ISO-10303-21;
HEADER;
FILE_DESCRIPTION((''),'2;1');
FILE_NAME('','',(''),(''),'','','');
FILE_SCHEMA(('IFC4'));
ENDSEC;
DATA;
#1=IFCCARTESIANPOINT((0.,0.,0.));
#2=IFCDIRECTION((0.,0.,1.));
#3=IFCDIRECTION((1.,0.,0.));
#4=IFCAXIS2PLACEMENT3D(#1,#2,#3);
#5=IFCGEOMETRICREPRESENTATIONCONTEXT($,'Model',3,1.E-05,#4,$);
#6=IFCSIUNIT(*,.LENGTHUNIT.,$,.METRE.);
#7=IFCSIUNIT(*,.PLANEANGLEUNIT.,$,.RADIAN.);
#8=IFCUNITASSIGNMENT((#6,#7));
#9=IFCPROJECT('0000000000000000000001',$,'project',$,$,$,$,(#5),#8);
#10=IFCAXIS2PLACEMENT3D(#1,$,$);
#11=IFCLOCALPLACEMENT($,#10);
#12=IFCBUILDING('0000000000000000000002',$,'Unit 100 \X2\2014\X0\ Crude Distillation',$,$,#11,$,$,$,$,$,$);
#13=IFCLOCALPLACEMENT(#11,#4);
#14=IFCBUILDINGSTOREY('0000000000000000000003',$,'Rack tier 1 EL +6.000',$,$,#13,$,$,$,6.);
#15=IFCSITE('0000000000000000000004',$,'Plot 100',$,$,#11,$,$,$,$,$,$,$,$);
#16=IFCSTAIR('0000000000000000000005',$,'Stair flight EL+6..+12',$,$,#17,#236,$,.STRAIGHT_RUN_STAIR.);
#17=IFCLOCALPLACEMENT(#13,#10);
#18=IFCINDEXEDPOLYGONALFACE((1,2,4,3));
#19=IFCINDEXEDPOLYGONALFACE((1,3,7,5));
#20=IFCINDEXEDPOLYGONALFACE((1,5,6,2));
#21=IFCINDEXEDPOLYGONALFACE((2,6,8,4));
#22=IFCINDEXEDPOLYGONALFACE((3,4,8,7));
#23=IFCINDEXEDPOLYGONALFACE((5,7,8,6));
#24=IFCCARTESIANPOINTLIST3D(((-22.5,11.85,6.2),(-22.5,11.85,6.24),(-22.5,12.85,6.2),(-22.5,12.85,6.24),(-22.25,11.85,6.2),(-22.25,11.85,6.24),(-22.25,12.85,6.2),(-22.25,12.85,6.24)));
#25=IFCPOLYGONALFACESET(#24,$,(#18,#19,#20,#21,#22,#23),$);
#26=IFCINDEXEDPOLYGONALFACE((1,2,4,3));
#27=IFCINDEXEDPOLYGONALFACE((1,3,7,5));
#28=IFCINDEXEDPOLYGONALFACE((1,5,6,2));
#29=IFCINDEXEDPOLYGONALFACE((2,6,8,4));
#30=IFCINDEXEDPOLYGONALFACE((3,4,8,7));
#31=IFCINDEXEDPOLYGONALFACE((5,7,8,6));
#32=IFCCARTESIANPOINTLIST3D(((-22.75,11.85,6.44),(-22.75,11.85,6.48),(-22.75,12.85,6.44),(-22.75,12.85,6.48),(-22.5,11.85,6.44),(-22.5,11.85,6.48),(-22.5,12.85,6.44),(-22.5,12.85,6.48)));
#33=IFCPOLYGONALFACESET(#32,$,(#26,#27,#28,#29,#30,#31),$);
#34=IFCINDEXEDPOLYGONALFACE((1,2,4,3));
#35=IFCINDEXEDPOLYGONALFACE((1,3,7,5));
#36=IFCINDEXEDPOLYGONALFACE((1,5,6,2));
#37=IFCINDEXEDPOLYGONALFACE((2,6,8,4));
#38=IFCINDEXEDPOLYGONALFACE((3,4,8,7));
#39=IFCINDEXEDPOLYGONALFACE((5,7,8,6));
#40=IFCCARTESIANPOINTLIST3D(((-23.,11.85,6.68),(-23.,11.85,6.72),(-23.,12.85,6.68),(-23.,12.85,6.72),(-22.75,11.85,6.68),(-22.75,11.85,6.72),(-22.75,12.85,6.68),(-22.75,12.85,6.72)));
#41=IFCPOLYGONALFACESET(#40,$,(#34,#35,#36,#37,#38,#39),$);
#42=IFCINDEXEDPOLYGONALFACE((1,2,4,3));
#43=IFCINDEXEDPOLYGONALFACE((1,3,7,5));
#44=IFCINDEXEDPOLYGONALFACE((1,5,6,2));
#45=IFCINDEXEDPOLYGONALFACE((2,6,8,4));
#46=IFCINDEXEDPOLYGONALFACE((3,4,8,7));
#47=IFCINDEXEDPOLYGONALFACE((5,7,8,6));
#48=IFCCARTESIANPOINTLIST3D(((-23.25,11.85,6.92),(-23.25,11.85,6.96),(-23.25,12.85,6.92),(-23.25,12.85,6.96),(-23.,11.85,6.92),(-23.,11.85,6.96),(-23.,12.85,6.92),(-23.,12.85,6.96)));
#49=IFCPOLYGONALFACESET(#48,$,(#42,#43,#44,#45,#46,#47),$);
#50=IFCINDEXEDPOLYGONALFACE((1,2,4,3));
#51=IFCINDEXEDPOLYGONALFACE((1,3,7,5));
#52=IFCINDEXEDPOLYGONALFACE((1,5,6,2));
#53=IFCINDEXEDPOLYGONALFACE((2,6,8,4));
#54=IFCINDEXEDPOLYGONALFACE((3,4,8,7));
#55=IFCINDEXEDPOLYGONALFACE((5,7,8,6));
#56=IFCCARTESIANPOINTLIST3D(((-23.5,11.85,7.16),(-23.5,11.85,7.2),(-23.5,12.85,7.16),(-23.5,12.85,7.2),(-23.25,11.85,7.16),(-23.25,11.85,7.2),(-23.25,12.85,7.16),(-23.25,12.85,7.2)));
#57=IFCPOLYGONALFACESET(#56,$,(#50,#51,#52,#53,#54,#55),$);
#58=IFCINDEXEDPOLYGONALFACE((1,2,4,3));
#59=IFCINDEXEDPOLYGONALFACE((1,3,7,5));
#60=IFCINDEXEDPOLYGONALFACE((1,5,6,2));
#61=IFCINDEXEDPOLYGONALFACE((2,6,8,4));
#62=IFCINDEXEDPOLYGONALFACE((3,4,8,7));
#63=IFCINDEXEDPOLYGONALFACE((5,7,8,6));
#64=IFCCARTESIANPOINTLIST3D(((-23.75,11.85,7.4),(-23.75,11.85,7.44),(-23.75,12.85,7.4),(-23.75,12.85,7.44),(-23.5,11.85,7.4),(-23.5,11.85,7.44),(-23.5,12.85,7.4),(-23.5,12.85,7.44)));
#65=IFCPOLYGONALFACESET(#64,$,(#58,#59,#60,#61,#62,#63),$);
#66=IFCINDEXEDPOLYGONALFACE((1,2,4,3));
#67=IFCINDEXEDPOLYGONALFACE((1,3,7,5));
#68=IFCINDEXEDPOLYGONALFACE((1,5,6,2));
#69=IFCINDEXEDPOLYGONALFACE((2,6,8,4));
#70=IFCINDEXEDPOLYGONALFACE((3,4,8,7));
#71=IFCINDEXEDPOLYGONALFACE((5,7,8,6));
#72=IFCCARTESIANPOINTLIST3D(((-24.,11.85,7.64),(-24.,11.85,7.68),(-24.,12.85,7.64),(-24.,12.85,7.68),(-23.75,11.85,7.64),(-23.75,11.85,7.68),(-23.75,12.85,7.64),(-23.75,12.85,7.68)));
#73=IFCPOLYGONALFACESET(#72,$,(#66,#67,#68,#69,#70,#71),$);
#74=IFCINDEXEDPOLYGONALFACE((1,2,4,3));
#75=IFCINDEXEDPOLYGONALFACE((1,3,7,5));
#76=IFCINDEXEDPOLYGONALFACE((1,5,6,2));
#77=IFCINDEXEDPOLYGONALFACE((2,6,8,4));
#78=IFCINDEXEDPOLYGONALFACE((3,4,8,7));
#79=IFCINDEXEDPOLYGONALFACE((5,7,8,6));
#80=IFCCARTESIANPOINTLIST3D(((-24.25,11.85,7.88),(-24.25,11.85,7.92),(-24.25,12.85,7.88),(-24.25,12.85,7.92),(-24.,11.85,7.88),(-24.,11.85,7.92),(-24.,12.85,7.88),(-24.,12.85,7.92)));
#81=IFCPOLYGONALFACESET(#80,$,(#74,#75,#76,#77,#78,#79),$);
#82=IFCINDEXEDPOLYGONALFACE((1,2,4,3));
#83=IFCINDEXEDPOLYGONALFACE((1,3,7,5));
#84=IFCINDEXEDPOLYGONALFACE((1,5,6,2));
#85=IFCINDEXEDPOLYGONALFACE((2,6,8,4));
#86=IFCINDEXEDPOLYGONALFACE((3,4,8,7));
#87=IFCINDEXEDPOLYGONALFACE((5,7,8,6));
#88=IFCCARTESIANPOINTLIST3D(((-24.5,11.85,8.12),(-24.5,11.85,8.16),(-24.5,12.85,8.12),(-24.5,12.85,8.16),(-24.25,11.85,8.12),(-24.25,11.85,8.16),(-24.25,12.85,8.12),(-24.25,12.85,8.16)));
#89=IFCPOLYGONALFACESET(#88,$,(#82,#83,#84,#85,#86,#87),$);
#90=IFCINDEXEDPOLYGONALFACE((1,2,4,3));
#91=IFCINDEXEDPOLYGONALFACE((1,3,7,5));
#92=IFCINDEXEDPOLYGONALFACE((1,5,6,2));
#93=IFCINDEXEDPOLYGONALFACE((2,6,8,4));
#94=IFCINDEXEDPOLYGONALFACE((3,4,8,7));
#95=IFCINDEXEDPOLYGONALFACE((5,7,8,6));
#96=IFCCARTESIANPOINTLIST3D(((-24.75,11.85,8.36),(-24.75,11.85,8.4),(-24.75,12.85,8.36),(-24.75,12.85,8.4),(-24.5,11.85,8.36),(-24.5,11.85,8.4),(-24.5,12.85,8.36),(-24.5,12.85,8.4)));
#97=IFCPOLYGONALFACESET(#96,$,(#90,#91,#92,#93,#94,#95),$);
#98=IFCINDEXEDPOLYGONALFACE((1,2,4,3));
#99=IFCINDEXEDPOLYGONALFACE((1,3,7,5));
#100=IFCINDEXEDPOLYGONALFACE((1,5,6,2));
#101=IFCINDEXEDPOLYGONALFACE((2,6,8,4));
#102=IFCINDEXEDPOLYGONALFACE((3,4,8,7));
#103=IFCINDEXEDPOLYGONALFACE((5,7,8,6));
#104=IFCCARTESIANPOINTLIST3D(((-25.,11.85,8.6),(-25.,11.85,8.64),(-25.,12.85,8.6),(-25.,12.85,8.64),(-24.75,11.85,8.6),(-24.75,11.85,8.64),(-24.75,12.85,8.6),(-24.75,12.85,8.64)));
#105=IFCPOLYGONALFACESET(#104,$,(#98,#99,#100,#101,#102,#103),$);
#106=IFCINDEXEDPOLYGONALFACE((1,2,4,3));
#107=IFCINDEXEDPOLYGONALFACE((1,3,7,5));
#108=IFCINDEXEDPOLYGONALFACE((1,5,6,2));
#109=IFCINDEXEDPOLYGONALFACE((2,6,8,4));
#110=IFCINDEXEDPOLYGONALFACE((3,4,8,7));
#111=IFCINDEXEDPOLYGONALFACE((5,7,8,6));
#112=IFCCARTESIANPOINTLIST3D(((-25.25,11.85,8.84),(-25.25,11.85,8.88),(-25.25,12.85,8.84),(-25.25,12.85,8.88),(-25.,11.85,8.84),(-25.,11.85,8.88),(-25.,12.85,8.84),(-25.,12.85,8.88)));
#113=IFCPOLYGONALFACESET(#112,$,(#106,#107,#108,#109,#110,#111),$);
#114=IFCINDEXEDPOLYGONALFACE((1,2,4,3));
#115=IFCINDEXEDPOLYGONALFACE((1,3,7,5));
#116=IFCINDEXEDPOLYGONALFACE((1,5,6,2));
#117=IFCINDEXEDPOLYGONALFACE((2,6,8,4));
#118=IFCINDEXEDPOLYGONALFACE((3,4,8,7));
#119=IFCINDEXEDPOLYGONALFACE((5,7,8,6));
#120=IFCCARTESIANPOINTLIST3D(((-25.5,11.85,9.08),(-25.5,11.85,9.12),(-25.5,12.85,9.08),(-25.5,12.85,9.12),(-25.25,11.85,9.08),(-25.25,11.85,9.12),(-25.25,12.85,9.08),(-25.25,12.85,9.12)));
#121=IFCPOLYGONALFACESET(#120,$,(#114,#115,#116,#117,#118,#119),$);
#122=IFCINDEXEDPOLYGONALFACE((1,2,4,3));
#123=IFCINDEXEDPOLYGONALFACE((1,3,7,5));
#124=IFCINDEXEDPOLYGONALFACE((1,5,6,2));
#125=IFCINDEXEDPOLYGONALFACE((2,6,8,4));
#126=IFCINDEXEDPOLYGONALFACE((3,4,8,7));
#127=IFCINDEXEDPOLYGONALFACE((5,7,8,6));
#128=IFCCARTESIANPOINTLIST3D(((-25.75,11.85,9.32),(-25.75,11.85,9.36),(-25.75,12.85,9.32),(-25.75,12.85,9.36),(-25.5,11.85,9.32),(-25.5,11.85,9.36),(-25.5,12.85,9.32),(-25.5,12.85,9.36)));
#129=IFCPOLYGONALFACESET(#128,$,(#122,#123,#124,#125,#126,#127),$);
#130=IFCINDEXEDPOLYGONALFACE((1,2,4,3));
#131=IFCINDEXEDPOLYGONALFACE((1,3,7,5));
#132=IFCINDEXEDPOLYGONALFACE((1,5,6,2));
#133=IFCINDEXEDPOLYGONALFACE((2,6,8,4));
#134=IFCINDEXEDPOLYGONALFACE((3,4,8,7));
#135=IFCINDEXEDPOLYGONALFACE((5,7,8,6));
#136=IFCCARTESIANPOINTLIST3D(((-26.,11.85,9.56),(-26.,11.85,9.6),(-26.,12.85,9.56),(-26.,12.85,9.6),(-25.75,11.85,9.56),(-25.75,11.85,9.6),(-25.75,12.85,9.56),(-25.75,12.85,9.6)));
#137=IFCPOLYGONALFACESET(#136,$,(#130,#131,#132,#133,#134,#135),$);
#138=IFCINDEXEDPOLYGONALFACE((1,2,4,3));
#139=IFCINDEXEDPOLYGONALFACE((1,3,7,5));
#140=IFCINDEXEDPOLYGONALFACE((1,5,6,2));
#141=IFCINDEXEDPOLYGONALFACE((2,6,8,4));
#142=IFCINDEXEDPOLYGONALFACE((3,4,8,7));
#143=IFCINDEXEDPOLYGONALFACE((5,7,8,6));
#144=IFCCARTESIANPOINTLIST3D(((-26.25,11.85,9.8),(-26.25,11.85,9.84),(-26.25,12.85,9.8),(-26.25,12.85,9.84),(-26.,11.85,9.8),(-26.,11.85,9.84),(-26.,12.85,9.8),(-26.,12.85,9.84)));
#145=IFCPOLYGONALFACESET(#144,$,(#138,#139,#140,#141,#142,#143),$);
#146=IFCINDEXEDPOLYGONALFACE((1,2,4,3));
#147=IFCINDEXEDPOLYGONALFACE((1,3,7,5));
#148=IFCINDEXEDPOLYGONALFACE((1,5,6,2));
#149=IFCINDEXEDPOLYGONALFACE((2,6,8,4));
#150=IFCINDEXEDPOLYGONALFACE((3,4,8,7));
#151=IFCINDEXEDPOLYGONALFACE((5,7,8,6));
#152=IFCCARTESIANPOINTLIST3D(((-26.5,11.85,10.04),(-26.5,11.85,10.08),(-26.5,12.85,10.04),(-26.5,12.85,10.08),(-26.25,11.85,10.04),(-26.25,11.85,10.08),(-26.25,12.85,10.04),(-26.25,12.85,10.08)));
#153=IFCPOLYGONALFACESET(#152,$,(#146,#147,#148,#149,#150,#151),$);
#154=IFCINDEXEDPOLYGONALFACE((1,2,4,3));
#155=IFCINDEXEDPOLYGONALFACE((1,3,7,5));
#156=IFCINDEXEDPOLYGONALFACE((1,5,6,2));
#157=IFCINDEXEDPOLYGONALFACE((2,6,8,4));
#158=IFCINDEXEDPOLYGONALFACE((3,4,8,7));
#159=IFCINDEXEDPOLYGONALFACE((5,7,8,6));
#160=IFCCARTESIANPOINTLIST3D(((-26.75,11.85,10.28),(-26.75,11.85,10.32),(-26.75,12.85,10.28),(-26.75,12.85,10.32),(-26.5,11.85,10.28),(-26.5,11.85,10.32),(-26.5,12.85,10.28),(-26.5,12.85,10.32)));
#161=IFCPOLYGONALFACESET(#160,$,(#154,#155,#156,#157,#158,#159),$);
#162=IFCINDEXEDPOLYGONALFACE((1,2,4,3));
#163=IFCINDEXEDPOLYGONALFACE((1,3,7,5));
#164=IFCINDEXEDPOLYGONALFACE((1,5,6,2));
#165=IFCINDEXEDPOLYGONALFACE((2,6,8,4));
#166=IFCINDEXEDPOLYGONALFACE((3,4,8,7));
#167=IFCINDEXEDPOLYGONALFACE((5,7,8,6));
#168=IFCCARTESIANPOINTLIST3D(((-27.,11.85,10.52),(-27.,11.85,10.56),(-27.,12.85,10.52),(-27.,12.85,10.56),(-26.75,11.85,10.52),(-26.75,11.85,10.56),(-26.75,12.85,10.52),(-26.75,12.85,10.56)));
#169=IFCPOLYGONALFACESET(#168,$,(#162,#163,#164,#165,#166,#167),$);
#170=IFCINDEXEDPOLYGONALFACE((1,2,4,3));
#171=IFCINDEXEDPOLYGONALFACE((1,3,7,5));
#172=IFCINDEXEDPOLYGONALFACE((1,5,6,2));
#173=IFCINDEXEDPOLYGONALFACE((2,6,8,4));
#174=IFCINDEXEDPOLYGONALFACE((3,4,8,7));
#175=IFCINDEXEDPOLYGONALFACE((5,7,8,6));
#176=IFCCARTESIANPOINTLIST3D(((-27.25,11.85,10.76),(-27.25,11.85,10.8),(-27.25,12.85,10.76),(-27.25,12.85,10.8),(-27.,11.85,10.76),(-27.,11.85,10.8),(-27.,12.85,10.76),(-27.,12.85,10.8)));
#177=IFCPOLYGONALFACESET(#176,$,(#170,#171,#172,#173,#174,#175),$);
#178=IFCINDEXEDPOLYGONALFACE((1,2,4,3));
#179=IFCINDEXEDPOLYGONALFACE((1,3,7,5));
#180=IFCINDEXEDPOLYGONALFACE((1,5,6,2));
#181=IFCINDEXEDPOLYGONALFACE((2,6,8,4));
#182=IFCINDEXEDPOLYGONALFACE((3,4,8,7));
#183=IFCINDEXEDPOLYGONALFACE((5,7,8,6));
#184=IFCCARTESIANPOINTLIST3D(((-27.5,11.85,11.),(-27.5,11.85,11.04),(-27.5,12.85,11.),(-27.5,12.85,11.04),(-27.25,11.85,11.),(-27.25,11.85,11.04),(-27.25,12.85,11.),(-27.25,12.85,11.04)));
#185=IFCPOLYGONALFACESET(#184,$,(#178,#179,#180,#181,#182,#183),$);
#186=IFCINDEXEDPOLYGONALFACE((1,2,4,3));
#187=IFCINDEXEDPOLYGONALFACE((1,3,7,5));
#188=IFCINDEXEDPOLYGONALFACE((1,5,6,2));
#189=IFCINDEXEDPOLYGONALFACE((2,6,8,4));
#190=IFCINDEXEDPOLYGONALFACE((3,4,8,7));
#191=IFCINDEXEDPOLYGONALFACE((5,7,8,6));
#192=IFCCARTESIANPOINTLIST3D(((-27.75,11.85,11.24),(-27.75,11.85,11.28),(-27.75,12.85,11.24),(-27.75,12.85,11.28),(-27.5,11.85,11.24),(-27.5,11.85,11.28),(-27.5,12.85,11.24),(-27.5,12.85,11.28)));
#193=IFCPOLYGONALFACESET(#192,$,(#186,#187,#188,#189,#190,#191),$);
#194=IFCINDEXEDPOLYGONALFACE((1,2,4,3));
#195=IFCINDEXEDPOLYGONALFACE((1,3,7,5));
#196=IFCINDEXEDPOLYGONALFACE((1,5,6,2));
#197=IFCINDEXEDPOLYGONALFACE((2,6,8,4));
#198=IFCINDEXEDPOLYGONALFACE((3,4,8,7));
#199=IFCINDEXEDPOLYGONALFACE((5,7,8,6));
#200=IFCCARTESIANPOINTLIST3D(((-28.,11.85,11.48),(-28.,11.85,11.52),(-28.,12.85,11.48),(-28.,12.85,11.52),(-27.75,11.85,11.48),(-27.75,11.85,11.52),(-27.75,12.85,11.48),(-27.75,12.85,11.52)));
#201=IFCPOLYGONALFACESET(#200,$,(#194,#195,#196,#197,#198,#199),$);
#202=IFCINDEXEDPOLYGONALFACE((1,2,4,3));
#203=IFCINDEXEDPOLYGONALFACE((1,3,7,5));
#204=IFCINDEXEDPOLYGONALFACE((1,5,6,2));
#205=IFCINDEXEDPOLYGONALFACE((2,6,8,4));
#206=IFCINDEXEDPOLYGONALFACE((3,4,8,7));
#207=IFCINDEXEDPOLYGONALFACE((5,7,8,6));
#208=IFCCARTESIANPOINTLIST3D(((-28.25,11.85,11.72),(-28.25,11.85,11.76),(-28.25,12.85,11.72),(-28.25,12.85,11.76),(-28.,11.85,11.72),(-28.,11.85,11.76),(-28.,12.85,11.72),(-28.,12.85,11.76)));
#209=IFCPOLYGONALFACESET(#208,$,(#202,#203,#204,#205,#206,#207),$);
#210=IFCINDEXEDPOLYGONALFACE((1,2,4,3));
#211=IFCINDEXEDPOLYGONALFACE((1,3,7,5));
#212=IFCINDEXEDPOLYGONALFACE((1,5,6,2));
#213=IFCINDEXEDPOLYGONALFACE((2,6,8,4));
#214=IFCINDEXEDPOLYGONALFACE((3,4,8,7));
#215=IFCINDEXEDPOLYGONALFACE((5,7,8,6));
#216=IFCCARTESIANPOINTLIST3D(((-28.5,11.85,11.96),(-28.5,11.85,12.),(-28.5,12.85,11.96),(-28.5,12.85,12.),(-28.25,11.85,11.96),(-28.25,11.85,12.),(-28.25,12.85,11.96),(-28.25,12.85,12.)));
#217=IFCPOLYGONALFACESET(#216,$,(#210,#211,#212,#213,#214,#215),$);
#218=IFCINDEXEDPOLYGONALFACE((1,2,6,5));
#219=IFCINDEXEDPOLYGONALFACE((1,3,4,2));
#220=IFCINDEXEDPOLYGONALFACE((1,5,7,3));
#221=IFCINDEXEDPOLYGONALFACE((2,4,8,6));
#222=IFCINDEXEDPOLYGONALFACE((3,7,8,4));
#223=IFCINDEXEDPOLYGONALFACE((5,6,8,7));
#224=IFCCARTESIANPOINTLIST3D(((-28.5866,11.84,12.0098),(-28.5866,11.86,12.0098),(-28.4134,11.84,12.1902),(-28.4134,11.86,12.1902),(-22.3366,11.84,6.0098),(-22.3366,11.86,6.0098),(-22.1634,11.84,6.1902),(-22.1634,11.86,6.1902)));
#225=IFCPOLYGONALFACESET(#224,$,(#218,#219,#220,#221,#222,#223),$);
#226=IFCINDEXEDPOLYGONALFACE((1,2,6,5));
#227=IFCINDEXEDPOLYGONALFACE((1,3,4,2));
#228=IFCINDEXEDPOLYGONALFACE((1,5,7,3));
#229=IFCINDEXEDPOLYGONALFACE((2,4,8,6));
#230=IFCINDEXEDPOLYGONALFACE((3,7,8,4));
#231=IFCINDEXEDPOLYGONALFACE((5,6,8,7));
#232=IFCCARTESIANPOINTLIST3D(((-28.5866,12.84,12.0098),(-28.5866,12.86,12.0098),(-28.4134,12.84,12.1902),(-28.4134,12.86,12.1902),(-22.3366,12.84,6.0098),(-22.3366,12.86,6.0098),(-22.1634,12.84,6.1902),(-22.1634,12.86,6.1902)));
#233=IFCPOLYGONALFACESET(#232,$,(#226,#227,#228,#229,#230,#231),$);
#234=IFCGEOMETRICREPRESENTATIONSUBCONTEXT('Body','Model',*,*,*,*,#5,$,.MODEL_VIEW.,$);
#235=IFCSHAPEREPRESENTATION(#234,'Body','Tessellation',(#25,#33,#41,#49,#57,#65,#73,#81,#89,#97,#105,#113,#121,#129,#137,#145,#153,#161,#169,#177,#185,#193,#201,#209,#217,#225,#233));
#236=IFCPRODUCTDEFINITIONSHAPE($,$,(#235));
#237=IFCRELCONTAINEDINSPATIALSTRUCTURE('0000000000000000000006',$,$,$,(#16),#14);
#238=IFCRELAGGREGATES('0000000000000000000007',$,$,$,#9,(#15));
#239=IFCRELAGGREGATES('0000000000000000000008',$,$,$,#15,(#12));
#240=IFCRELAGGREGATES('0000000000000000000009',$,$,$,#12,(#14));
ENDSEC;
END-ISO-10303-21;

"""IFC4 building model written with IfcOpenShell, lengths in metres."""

from ifc_helpers import new_model, si_unit, frame, origin, origin_with_axes, origin_2d, place, context, subcontext, project, spatial, rectangle, extrude, element, save


model = new_model("IFC4")

# Units and contexts
model_context = context("Model", 3, precision=1e-05, world=origin_with_axes())
body_context = subcontext(model_context, "Body", "Model", "MODEL_VIEW")
ifc_project = project(units=[si_unit("LENGTHUNIT", "METRE"), si_unit("PLANEANGLEUNIT", "RADIAN")], contexts=[model_context])

# Site, building, storey
placement = place(None, origin())
site = spatial("IfcSite", under=ifc_project, at=placement, Name="Plot 100")
building = spatial("IfcBuilding", under=site, at=placement, Name="Unit 100 — Crude Distillation")
storey_placement = place(placement, origin_with_axes())
storey = spatial("IfcBuildingStorey", under=building, at=storey_placement, Name="Rack tier 1 EL +6.000", Elevation=6.0)

# Stair
stair_placement = place(storey_placement, origin_with_axes())
element("IfcStair", 1, at=stair_placement, inside=storey, Name="Stair flight EL+6..+12", PredefinedType="STRAIGHT_RUN_STAIR", context=body_context, shape_type="SweptSolid", body=[
    extrude(rectangle(XDim=0.25, YDim=1.0, at=origin_2d()), frame((-22.375, 12.35, 6.2), z_axis=(0.0, 0.0, 1.0), x_axis=(1.0, 0.0, 0.0)), (0.0, 0.0, 1.0), 0.04),
    extrude(rectangle(XDim=0.25, YDim=1.0, at=origin_2d()), frame((-22.625, 12.35, 6.44), z_axis=(0.0, 0.0, 1.0), x_axis=(1.0, 0.0, 0.0)), (0.0, 0.0, 1.0), 0.04),
    extrude(rectangle(XDim=0.25, YDim=1.0, at=origin_2d()), frame((-22.875, 12.35, 6.68), z_axis=(0.0, 0.0, 1.0), x_axis=(1.0, 0.0, 0.0)), (0.0, 0.0, 1.0), 0.04),
    extrude(rectangle(XDim=0.25, YDim=1.0, at=origin_2d()), frame((-23.125, 12.35, 6.92), z_axis=(0.0, 0.0, 1.0), x_axis=(1.0, 0.0, 0.0)), (0.0, 0.0, 1.0), 0.04),
    extrude(rectangle(XDim=0.25, YDim=1.0, at=origin_2d()), frame((-23.375, 12.35, 7.16), z_axis=(0.0, 0.0, 1.0), x_axis=(1.0, 0.0, 0.0)), (0.0, 0.0, 1.0), 0.04),
    extrude(rectangle(XDim=0.25, YDim=1.0, at=origin_2d()), frame((-23.625, 12.35, 7.4), z_axis=(0.0, 0.0, 1.0), x_axis=(1.0, 0.0, 0.0)), (0.0, 0.0, 1.0), 0.04),
    extrude(rectangle(XDim=0.25, YDim=1.0, at=origin_2d()), frame((-23.875, 12.35, 7.64), z_axis=(0.0, 0.0, 1.0), x_axis=(1.0, 0.0, 0.0)), (0.0, 0.0, 1.0), 0.04),
    extrude(rectangle(XDim=0.25, YDim=1.0, at=origin_2d()), frame((-24.125, 12.35, 7.88), z_axis=(0.0, 0.0, 1.0), x_axis=(1.0, 0.0, 0.0)), (0.0, 0.0, 1.0), 0.04),
    extrude(rectangle(XDim=0.25, YDim=1.0, at=origin_2d()), frame((-24.375, 12.35, 8.12), z_axis=(0.0, 0.0, 1.0), x_axis=(1.0, 0.0, 0.0)), (0.0, 0.0, 1.0), 0.04),
    extrude(rectangle(XDim=0.25, YDim=1.0, at=origin_2d()), frame((-24.625, 12.35, 8.36), z_axis=(0.0, 0.0, 1.0), x_axis=(1.0, 0.0, 0.0)), (0.0, 0.0, 1.0), 0.04),
    extrude(rectangle(XDim=0.25, YDim=1.0, at=origin_2d()), frame((-24.875, 12.35, 8.6), z_axis=(0.0, 0.0, 1.0), x_axis=(1.0, 0.0, 0.0)), (0.0, 0.0, 1.0), 0.04),
    extrude(rectangle(XDim=0.25, YDim=1.0, at=origin_2d()), frame((-25.125, 12.35, 8.84), z_axis=(0.0, 0.0, 1.0), x_axis=(1.0, 0.0, 0.0)), (0.0, 0.0, 1.0), 0.04),
    extrude(rectangle(XDim=0.25, YDim=1.0, at=origin_2d()), frame((-25.375, 12.35, 9.08), z_axis=(0.0, 0.0, 1.0), x_axis=(1.0, 0.0, 0.0)), (0.0, 0.0, 1.0), 0.04),
    extrude(rectangle(XDim=0.25, YDim=1.0, at=origin_2d()), frame((-25.625, 12.35, 9.32), z_axis=(0.0, 0.0, 1.0), x_axis=(1.0, 0.0, 0.0)), (0.0, 0.0, 1.0), 0.04),
    extrude(rectangle(XDim=0.25, YDim=1.0, at=origin_2d()), frame((-25.875, 12.35, 9.56), z_axis=(0.0, 0.0, 1.0), x_axis=(1.0, 0.0, 0.0)), (0.0, 0.0, 1.0), 0.04),
    extrude(rectangle(XDim=0.25, YDim=1.0, at=origin_2d()), frame((-26.125, 12.35, 9.8), z_axis=(0.0, 0.0, 1.0), x_axis=(1.0, 0.0, 0.0)), (0.0, 0.0, 1.0), 0.04),
    extrude(rectangle(XDim=0.25, YDim=1.0, at=origin_2d()), frame((-26.375, 12.35, 10.04), z_axis=(0.0, 0.0, 1.0), x_axis=(1.0, 0.0, 0.0)), (0.0, 0.0, 1.0), 0.04),
    extrude(rectangle(XDim=0.25, YDim=1.0, at=origin_2d()), frame((-26.625, 12.35, 10.28), z_axis=(0.0, 0.0, 1.0), x_axis=(1.0, 0.0, 0.0)), (0.0, 0.0, 1.0), 0.04),
    extrude(rectangle(XDim=0.25, YDim=1.0, at=origin_2d()), frame((-26.875, 12.35, 10.52), z_axis=(0.0, 0.0, 1.0), x_axis=(1.0, 0.0, 0.0)), (0.0, 0.0, 1.0), 0.04),
    extrude(rectangle(XDim=0.25, YDim=1.0, at=origin_2d()), frame((-27.125, 12.35, 10.76), z_axis=(0.0, 0.0, 1.0), x_axis=(1.0, 0.0, 0.0)), (0.0, 0.0, 1.0), 0.04),
    extrude(rectangle(XDim=0.25, YDim=1.0, at=origin_2d()), frame((-27.375, 12.35, 11.0), z_axis=(0.0, 0.0, 1.0), x_axis=(1.0, 0.0, 0.0)), (0.0, 0.0, 1.0), 0.04),
    extrude(rectangle(XDim=0.25, YDim=1.0, at=origin_2d()), frame((-27.625, 12.35, 11.24), z_axis=(0.0, 0.0, 1.0), x_axis=(1.0, 0.0, 0.0)), (0.0, 0.0, 1.0), 0.04),
    extrude(rectangle(XDim=0.25, YDim=1.0, at=origin_2d()), frame((-27.875, 12.35, 11.48), z_axis=(0.0, 0.0, 1.0), x_axis=(1.0, 0.0, 0.0)), (0.0, 0.0, 1.0), 0.04),
    extrude(rectangle(XDim=0.25, YDim=1.0, at=origin_2d()), frame((-28.125, 12.35, 11.72), z_axis=(0.0, 0.0, 1.0), x_axis=(1.0, 0.0, 0.0)), (0.0, 0.0, 1.0), 0.04),
    extrude(rectangle(XDim=0.25, YDim=1.0, at=origin_2d()), frame((-28.375, 12.35, 11.96), z_axis=(0.0, 0.0, 1.0), x_axis=(1.0, 0.0, 0.0)), (0.0, 0.0, 1.0), 0.04),
    extrude(rectangle(XDim=0.02, YDim=0.25, at=origin_2d()), frame((-22.25, 11.85, 6.1), z_axis=(-0.721387, 0.0, 0.692532), x_axis=(0.0, -1.0, 0.0)), (0.0, 0.0, 1.0), 8.6639),
    extrude(rectangle(XDim=0.02, YDim=0.25, at=origin_2d()), frame((-22.25, 12.85, 6.1), z_axis=(-0.721387, 0.0, 0.692532), x_axis=(0.0, -1.0, 0.0)), (0.0, 0.0, 1.0), 8.6639),
])

save(model, "model.ifc")
